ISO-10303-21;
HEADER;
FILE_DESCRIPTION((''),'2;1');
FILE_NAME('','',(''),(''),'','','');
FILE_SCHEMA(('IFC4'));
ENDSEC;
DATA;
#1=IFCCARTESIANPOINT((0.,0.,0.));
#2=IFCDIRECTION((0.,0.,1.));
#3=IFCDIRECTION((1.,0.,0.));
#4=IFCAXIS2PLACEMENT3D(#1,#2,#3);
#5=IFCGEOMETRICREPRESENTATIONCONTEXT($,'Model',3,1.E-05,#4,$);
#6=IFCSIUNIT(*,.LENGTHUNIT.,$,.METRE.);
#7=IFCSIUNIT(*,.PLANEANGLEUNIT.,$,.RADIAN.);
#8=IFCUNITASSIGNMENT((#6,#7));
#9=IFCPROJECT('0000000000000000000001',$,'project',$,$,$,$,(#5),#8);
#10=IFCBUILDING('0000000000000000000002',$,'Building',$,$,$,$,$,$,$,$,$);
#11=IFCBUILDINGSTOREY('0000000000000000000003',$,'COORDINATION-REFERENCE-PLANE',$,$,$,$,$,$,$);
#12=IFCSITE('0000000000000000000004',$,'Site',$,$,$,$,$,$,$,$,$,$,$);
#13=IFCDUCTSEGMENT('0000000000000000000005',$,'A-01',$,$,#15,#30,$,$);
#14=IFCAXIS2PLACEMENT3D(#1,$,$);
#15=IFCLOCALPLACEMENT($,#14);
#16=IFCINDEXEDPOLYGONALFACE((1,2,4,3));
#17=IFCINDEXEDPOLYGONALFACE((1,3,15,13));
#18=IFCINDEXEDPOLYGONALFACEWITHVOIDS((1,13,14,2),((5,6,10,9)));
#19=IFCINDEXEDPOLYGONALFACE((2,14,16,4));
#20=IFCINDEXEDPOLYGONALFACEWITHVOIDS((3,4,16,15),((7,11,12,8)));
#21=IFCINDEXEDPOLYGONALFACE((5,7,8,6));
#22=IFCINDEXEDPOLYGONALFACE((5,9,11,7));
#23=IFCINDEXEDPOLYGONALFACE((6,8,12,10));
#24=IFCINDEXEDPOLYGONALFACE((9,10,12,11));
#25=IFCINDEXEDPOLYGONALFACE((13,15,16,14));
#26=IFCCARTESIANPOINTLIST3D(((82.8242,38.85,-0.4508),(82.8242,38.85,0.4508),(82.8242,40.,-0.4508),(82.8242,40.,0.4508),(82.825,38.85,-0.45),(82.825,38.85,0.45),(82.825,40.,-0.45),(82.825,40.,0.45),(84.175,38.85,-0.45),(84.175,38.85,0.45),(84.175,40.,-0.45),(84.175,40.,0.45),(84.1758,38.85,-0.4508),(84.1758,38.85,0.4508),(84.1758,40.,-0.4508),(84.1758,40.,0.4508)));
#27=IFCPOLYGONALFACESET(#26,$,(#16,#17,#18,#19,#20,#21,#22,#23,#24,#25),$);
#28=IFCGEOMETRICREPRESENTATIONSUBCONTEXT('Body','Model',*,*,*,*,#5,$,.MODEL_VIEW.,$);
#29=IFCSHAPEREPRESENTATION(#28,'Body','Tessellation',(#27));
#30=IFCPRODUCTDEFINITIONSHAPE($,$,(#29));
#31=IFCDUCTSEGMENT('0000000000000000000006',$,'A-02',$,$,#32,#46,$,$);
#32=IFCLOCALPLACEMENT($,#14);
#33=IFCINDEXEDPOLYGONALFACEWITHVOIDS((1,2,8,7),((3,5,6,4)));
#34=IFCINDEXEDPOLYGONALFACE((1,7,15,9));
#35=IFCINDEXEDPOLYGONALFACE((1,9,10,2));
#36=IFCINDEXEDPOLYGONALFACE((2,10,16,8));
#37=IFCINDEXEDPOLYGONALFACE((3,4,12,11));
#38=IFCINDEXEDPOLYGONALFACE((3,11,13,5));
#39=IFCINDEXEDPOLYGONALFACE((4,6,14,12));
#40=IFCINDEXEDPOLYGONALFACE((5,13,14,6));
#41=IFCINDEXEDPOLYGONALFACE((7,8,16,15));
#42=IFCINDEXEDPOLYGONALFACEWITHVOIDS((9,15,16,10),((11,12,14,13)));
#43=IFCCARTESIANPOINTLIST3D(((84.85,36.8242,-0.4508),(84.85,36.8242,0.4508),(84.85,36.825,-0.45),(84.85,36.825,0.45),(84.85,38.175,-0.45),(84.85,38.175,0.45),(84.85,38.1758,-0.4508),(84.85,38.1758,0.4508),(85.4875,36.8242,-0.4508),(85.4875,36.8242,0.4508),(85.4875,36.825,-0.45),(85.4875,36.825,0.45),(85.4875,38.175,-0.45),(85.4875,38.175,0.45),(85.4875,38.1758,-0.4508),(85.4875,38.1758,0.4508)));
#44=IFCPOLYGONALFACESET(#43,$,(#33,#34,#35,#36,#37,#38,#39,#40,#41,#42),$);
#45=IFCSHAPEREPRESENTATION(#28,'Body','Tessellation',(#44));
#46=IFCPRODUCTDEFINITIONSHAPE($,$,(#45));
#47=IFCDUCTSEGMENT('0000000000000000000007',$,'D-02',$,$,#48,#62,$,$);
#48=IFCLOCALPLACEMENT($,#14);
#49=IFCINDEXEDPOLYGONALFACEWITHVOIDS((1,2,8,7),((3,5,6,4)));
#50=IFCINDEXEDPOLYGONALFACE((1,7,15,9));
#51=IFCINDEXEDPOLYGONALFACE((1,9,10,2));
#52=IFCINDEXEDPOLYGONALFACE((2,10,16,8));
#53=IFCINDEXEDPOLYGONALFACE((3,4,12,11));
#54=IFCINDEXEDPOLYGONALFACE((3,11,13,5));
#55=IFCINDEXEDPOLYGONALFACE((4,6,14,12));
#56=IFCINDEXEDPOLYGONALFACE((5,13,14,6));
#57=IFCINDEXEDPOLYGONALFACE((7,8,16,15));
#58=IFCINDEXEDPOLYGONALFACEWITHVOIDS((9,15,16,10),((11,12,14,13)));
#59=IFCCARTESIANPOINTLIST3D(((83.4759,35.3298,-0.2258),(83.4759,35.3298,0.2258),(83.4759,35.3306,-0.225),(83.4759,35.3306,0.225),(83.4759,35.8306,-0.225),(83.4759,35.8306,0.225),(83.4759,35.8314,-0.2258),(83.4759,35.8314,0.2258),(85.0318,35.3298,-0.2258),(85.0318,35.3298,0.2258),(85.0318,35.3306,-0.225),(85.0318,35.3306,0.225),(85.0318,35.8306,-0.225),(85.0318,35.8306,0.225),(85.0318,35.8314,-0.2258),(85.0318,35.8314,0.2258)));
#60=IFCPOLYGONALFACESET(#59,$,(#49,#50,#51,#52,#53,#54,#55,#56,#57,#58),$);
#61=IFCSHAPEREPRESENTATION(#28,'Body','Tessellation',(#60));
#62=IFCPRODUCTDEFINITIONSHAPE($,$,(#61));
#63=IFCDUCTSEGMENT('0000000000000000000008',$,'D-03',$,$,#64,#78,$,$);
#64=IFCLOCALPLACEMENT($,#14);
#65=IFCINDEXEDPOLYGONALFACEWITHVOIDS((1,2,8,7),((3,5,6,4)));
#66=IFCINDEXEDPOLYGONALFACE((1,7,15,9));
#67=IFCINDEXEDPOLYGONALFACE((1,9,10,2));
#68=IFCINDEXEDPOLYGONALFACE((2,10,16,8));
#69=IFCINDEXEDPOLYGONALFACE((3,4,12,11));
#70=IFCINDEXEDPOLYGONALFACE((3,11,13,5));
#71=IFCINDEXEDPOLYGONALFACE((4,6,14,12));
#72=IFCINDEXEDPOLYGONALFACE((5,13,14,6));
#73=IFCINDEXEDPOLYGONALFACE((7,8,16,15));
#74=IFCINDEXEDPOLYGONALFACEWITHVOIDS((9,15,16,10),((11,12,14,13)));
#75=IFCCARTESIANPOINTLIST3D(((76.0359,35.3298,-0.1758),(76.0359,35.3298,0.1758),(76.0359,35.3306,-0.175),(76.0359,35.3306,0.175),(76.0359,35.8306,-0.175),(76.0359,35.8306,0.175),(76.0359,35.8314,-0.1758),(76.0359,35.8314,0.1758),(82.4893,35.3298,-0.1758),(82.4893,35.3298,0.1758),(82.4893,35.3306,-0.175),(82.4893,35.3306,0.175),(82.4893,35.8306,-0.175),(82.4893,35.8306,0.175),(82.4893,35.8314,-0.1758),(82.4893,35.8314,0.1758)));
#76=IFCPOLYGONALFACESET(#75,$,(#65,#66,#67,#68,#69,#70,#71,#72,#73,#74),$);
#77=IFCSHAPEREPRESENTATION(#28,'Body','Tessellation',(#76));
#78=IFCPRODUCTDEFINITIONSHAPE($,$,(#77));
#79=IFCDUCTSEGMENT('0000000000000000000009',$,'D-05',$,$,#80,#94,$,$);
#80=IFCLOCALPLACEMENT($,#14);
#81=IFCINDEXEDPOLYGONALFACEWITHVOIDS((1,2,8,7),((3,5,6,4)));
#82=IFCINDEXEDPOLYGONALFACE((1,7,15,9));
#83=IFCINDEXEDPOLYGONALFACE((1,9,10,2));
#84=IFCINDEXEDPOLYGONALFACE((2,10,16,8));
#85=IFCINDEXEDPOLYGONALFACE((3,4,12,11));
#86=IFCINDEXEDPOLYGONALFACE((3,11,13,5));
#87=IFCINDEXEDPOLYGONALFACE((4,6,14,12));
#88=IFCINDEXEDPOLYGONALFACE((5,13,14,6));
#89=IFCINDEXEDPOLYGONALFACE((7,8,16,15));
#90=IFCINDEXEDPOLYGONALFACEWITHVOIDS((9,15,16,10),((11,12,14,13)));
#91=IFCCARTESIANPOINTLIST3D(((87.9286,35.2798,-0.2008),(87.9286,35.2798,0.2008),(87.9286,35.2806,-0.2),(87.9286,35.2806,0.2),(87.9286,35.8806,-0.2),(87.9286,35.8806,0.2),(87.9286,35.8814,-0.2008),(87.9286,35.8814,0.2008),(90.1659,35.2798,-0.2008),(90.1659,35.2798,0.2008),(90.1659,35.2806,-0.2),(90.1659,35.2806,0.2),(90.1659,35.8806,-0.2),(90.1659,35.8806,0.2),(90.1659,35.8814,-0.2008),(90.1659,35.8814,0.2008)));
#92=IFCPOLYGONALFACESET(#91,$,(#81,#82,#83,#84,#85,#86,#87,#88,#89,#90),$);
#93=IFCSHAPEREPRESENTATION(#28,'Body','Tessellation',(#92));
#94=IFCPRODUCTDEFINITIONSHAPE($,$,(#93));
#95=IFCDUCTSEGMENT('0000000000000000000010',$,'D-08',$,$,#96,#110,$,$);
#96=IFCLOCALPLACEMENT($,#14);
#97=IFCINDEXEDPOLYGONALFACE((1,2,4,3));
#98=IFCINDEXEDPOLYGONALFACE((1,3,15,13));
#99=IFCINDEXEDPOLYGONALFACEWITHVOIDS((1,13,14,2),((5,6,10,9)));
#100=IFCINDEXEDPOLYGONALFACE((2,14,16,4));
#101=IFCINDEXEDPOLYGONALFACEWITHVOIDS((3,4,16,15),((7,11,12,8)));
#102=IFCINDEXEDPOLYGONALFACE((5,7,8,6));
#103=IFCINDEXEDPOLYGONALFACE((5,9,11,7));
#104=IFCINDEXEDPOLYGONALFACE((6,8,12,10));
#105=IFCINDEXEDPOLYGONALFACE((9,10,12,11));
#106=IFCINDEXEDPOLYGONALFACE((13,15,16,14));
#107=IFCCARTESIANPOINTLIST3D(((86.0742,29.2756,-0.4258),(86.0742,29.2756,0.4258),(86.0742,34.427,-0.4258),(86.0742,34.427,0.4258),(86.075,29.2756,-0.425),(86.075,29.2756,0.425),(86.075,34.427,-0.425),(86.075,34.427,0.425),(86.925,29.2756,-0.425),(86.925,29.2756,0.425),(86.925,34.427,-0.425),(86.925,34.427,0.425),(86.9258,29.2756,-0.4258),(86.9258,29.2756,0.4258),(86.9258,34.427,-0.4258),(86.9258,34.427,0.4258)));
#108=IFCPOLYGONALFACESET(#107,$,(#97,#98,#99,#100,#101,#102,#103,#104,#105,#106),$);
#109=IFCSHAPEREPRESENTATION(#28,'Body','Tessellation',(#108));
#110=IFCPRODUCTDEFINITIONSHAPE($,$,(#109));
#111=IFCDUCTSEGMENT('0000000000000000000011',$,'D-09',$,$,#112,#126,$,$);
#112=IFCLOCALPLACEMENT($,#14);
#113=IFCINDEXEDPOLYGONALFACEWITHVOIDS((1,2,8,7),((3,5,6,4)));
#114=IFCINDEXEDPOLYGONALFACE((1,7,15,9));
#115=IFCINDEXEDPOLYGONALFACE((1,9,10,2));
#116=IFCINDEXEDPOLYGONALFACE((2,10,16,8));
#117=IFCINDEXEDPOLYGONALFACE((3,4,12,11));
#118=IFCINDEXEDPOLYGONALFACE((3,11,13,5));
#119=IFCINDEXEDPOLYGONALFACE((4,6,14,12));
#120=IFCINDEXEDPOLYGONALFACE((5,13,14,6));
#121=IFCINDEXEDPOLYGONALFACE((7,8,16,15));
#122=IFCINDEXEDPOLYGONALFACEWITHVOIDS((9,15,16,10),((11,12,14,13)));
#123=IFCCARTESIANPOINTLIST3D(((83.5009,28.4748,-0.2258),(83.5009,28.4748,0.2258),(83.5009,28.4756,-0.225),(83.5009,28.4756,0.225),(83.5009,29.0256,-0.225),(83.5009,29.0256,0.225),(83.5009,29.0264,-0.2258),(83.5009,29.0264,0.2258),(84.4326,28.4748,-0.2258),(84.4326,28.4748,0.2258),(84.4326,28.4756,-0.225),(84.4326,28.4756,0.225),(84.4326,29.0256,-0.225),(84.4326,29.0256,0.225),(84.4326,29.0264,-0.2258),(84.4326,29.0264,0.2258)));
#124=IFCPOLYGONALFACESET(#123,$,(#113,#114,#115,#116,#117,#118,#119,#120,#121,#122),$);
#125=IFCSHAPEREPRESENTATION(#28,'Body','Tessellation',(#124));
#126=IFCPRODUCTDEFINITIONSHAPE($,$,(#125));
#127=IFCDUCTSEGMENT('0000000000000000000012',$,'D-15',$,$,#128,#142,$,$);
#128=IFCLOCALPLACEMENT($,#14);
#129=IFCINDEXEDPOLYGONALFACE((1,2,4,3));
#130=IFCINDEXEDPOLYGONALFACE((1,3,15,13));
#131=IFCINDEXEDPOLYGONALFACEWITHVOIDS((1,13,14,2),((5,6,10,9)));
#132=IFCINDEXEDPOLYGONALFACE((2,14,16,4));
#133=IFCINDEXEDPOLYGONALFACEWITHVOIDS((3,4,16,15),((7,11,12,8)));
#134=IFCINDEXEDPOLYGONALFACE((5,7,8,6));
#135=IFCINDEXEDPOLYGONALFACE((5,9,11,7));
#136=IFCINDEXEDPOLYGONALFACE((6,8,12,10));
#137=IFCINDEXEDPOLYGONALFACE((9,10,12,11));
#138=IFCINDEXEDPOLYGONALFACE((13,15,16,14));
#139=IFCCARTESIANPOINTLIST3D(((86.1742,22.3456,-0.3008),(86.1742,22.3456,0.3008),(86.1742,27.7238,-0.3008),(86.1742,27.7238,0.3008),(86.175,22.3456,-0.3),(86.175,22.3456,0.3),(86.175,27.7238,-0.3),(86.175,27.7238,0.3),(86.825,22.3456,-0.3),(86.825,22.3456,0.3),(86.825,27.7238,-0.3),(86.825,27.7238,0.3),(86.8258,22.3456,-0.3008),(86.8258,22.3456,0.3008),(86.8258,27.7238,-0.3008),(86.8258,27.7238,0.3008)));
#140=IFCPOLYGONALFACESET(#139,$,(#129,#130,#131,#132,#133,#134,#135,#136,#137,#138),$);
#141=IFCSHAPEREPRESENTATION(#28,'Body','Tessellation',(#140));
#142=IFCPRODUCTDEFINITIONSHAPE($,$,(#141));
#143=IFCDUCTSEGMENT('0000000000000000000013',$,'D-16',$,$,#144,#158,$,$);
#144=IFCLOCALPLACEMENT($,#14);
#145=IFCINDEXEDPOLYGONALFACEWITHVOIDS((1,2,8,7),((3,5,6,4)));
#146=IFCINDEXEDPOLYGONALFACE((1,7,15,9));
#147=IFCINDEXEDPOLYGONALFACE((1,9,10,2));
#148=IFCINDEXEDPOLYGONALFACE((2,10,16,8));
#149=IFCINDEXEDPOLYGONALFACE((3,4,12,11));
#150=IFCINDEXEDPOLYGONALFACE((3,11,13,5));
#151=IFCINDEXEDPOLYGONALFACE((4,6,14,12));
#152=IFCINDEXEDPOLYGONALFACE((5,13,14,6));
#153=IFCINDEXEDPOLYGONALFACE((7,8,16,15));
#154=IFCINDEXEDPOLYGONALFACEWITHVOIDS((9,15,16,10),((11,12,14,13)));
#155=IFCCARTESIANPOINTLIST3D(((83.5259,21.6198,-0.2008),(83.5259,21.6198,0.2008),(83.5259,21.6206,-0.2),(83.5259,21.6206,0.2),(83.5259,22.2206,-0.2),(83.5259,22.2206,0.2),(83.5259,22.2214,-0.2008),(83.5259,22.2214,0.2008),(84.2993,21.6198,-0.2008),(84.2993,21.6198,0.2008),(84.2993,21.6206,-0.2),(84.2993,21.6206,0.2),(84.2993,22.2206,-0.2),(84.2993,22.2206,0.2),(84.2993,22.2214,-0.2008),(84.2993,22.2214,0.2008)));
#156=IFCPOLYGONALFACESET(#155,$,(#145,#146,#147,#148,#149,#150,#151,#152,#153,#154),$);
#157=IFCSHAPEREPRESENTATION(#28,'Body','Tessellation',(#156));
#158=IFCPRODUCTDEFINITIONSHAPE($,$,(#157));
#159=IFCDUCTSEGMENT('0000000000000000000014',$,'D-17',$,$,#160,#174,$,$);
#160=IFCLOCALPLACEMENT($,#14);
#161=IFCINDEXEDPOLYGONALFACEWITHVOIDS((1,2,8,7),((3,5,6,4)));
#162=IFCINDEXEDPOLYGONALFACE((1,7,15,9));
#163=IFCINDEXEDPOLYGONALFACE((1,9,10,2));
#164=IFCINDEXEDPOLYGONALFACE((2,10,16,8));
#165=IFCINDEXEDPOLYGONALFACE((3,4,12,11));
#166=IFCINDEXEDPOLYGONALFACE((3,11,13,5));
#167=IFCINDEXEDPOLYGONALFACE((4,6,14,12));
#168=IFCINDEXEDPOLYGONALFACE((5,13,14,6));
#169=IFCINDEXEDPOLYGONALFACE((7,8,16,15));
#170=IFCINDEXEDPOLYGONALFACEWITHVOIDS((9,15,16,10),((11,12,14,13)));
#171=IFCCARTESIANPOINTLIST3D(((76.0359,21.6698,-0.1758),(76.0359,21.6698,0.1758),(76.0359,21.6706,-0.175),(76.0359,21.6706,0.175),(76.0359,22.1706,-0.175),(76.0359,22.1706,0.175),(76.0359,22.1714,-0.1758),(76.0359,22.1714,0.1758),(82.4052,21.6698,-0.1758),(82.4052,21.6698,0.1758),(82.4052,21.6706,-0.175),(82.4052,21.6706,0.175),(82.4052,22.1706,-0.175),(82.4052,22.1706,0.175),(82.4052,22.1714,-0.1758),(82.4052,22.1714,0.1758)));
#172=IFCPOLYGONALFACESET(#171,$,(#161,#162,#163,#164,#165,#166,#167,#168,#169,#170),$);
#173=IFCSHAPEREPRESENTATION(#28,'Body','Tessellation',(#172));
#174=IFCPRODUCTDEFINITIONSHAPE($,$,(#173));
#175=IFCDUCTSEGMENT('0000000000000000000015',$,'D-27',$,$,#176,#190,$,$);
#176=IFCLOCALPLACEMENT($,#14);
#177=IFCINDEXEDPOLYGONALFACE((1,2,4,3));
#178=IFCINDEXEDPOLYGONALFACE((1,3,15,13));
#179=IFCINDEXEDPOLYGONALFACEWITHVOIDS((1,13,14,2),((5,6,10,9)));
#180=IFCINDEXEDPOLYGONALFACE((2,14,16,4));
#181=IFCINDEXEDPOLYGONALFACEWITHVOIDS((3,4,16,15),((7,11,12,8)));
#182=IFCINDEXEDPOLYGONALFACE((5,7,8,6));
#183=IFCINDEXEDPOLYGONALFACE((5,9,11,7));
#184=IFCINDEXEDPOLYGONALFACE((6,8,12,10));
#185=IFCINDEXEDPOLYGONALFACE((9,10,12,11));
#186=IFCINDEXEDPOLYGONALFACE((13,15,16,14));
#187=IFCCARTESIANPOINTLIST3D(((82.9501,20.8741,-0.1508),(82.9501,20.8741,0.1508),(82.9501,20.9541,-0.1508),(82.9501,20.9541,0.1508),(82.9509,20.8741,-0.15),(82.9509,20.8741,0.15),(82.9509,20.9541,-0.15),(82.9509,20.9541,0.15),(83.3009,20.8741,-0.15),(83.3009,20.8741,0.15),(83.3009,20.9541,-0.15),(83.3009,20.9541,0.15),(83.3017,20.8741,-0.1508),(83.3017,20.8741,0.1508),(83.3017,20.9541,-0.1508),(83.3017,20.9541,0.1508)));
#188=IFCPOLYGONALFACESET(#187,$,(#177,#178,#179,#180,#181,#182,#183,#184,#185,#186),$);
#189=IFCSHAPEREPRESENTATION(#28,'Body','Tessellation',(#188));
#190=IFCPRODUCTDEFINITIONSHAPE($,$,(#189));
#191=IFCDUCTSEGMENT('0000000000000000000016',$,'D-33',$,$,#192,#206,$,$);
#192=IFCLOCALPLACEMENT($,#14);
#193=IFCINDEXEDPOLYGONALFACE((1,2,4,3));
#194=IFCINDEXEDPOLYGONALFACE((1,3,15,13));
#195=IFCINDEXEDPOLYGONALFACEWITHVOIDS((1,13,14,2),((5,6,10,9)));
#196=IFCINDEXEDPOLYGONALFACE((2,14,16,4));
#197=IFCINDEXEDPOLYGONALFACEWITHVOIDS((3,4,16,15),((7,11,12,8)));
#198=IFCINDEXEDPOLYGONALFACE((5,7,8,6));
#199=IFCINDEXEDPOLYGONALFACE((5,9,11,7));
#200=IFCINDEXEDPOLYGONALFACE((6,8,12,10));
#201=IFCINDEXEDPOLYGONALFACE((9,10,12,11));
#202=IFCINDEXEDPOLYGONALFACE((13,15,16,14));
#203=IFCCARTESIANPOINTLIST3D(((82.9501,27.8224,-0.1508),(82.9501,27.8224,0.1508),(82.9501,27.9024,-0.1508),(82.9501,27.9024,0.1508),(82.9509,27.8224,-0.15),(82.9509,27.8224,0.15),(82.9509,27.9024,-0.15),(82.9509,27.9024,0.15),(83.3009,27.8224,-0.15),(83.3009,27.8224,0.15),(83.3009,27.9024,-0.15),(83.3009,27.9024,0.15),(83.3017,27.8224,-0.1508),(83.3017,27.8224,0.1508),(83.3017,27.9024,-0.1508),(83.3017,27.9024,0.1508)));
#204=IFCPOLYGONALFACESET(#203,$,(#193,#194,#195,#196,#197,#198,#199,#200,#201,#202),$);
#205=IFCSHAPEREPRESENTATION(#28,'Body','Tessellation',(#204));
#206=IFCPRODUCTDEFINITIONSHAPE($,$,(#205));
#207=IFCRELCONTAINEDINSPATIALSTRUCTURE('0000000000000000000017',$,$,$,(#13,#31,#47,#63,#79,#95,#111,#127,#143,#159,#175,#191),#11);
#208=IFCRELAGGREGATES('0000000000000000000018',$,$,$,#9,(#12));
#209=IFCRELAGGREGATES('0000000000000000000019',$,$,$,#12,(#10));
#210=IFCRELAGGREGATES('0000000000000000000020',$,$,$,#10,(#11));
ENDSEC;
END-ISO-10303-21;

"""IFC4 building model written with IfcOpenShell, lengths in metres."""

from ifc_helpers import new_model, si_unit, frame, origin, origin_with_axes, place, context, subcontext, project, spatial, hollow_rectangle, extrude, element, save


model = new_model("IFC4")

# Units and contexts
model_context = context("Model", 3, precision=1e-05, world=origin_with_axes())
body_context_1 = subcontext(model_context, "Body", "Model", "MODEL_VIEW")
ifc_project = project(units=[si_unit("LENGTHUNIT", "METRE"), si_unit("PLANEANGLEUNIT", "RADIAN")], contexts=[model_context])

# Site, building, storey
site = spatial("IfcSite", under=ifc_project, Name="Site")
building = spatial("IfcBuilding", under=site, Name="Building")
storey = spatial("IfcBuildingStorey", under=building, Name="COORDINATION-REFERENCE-PLANE")

# Duct segments
duct_segment_1_placement = place(None, frame((83.5, 38.85, 0.0), z_axis=(0.0, 1.0, 0.0), x_axis=(1.0, 0.0, 0.0)))
element("IfcDuctSegment", 1, at=duct_segment_1_placement, inside=storey, Name="A-01", context=body_context_1, shape_type="SweptSolid", body=[
    extrude(hollow_rectangle(XDim=1.3516, YDim=0.9016, WallThickness=0.0008), origin(), (0.0, 0.0, 1.0), 1.15),
])
duct_segment_2_placement = place(None, frame((84.85, 37.5, 0.0), z_axis=(1.0, 0.0, 0.0), x_axis=(0.0, 1.0, 0.0)))
element("IfcDuctSegment", 2, at=duct_segment_2_placement, inside=storey, Name="A-02", context=body_context_1, shape_type="SweptSolid", body=[
    extrude(hollow_rectangle(XDim=1.3516, YDim=0.9016, WallThickness=0.0008), origin(), (0.0, 0.0, 1.0), 0.6375),
])
duct_segment_3_placement = place(None, frame((83.4759, 35.5806, 0.0), z_axis=(1.0, 0.0, 0.0), x_axis=(0.0, 1.0, 0.0)))
element("IfcDuctSegment", 3, at=duct_segment_3_placement, inside=storey, Name="D-02", context=body_context_1, shape_type="SweptSolid", body=[
    extrude(hollow_rectangle(XDim=0.5016, YDim=0.4516, WallThickness=0.0008), origin(), (0.0, 0.0, 1.0), 1.5559),
])
duct_segment_4_placement = place(None, frame((76.0359, 35.5806, 0.0), z_axis=(1.0, 0.0, 0.0), x_axis=(0.0, 1.0, 0.0)))
element("IfcDuctSegment", 4, at=duct_segment_4_placement, inside=storey, Name="D-03", context=body_context_1, shape_type="SweptSolid", body=[
    extrude(hollow_rectangle(XDim=0.5016, YDim=0.3516, WallThickness=0.0008), origin(), (0.0, 0.0, 1.0), 6.4534),
])
duct_segment_5_placement = place(None, frame((87.9286, 35.5806, 0.0), z_axis=(1.0, 0.0, 0.0), x_axis=(0.0, 1.0, 0.0)))
element("IfcDuctSegment", 5, at=duct_segment_5_placement, inside=storey, Name="D-05", context=body_context_1, shape_type="SweptSolid", body=[
    extrude(hollow_rectangle(XDim=0.6016, YDim=0.4016, WallThickness=0.0008), origin(), (0.0, 0.0, 1.0), 2.2374),
])
duct_segment_6_placement = place(None, frame((86.5, 29.2756, 0.0), z_axis=(0.0, 1.0, 0.0), x_axis=(1.0, 0.0, 0.0)))
element("IfcDuctSegment", 6, at=duct_segment_6_placement, inside=storey, Name="D-08", context=body_context_1, shape_type="SweptSolid", body=[
    extrude(hollow_rectangle(XDim=0.8516, YDim=0.8516, WallThickness=0.0008), origin(), (0.0, 0.0, 1.0), 5.1514),
])
duct_segment_7_placement = place(None, frame((83.5009, 28.7506, 0.0), z_axis=(1.0, 0.0, 0.0), x_axis=(0.0, 1.0, 0.0)))
element("IfcDuctSegment", 7, at=duct_segment_7_placement, inside=storey, Name="D-09", context=body_context_1, shape_type="SweptSolid", body=[
    extrude(hollow_rectangle(XDim=0.5516, YDim=0.4516, WallThickness=0.0008), origin(), (0.0, 0.0, 1.0), 0.9316),
])
duct_segment_8_placement = place(None, frame((86.5, 22.3456, 0.0), z_axis=(0.0, 1.0, 0.0), x_axis=(1.0, 0.0, 0.0)))
element("IfcDuctSegment", 8, at=duct_segment_8_placement, inside=storey, Name="D-15", context=body_context_1, shape_type="SweptSolid", body=[
    extrude(hollow_rectangle(XDim=0.6516, YDim=0.6016, WallThickness=0.0008), origin(), (0.0, 0.0, 1.0), 5.3782),
])
duct_segment_9_placement = place(None, frame((83.5259, 21.9206, 0.0), z_axis=(1.0, 0.0, 0.0), x_axis=(0.0, 1.0, 0.0)))
element("IfcDuctSegment", 9, at=duct_segment_9_placement, inside=storey, Name="D-16", context=body_context_1, shape_type="SweptSolid", body=[
    extrude(hollow_rectangle(XDim=0.6016, YDim=0.4016, WallThickness=0.0008), origin(), (0.0, 0.0, 1.0), 0.7733),
])
duct_segment_10_placement = place(None, frame((76.0359, 21.9206, 0.0), z_axis=(1.0, 0.0, 0.0), x_axis=(0.0, 1.0, 0.0)))
element("IfcDuctSegment", 10, at=duct_segment_10_placement, inside=storey, Name="D-17", context=body_context_1, shape_type="SweptSolid", body=[
    extrude(hollow_rectangle(XDim=0.5016, YDim=0.3516, WallThickness=0.0008), origin(), (0.0, 0.0, 1.0), 6.3693),
])
for number, where, z_axis, x_axis, name in (
    (11, (83.1259, 20.8741, 0.0), (0.0, 1.0, 0.0), (1.0, 0.0, 0.0), "D-27"),
    (12, (83.1259, 27.8224, 0.0), (0.0, 1.0, 0.0), (1.0, 0.0, 0.0), "D-33"),
):
    element("IfcDuctSegment", number, at=place(None, frame(where, z_axis=z_axis, x_axis=x_axis)), inside=storey, Name=name, context=body_context_1, shape_type="SweptSolid", body=[
        extrude(hollow_rectangle(XDim=0.3516, YDim=0.3016, WallThickness=0.0008), origin(), (0.0, 0.0, 1.0), 0.08),
    ])

save(model, "model.ifc")
